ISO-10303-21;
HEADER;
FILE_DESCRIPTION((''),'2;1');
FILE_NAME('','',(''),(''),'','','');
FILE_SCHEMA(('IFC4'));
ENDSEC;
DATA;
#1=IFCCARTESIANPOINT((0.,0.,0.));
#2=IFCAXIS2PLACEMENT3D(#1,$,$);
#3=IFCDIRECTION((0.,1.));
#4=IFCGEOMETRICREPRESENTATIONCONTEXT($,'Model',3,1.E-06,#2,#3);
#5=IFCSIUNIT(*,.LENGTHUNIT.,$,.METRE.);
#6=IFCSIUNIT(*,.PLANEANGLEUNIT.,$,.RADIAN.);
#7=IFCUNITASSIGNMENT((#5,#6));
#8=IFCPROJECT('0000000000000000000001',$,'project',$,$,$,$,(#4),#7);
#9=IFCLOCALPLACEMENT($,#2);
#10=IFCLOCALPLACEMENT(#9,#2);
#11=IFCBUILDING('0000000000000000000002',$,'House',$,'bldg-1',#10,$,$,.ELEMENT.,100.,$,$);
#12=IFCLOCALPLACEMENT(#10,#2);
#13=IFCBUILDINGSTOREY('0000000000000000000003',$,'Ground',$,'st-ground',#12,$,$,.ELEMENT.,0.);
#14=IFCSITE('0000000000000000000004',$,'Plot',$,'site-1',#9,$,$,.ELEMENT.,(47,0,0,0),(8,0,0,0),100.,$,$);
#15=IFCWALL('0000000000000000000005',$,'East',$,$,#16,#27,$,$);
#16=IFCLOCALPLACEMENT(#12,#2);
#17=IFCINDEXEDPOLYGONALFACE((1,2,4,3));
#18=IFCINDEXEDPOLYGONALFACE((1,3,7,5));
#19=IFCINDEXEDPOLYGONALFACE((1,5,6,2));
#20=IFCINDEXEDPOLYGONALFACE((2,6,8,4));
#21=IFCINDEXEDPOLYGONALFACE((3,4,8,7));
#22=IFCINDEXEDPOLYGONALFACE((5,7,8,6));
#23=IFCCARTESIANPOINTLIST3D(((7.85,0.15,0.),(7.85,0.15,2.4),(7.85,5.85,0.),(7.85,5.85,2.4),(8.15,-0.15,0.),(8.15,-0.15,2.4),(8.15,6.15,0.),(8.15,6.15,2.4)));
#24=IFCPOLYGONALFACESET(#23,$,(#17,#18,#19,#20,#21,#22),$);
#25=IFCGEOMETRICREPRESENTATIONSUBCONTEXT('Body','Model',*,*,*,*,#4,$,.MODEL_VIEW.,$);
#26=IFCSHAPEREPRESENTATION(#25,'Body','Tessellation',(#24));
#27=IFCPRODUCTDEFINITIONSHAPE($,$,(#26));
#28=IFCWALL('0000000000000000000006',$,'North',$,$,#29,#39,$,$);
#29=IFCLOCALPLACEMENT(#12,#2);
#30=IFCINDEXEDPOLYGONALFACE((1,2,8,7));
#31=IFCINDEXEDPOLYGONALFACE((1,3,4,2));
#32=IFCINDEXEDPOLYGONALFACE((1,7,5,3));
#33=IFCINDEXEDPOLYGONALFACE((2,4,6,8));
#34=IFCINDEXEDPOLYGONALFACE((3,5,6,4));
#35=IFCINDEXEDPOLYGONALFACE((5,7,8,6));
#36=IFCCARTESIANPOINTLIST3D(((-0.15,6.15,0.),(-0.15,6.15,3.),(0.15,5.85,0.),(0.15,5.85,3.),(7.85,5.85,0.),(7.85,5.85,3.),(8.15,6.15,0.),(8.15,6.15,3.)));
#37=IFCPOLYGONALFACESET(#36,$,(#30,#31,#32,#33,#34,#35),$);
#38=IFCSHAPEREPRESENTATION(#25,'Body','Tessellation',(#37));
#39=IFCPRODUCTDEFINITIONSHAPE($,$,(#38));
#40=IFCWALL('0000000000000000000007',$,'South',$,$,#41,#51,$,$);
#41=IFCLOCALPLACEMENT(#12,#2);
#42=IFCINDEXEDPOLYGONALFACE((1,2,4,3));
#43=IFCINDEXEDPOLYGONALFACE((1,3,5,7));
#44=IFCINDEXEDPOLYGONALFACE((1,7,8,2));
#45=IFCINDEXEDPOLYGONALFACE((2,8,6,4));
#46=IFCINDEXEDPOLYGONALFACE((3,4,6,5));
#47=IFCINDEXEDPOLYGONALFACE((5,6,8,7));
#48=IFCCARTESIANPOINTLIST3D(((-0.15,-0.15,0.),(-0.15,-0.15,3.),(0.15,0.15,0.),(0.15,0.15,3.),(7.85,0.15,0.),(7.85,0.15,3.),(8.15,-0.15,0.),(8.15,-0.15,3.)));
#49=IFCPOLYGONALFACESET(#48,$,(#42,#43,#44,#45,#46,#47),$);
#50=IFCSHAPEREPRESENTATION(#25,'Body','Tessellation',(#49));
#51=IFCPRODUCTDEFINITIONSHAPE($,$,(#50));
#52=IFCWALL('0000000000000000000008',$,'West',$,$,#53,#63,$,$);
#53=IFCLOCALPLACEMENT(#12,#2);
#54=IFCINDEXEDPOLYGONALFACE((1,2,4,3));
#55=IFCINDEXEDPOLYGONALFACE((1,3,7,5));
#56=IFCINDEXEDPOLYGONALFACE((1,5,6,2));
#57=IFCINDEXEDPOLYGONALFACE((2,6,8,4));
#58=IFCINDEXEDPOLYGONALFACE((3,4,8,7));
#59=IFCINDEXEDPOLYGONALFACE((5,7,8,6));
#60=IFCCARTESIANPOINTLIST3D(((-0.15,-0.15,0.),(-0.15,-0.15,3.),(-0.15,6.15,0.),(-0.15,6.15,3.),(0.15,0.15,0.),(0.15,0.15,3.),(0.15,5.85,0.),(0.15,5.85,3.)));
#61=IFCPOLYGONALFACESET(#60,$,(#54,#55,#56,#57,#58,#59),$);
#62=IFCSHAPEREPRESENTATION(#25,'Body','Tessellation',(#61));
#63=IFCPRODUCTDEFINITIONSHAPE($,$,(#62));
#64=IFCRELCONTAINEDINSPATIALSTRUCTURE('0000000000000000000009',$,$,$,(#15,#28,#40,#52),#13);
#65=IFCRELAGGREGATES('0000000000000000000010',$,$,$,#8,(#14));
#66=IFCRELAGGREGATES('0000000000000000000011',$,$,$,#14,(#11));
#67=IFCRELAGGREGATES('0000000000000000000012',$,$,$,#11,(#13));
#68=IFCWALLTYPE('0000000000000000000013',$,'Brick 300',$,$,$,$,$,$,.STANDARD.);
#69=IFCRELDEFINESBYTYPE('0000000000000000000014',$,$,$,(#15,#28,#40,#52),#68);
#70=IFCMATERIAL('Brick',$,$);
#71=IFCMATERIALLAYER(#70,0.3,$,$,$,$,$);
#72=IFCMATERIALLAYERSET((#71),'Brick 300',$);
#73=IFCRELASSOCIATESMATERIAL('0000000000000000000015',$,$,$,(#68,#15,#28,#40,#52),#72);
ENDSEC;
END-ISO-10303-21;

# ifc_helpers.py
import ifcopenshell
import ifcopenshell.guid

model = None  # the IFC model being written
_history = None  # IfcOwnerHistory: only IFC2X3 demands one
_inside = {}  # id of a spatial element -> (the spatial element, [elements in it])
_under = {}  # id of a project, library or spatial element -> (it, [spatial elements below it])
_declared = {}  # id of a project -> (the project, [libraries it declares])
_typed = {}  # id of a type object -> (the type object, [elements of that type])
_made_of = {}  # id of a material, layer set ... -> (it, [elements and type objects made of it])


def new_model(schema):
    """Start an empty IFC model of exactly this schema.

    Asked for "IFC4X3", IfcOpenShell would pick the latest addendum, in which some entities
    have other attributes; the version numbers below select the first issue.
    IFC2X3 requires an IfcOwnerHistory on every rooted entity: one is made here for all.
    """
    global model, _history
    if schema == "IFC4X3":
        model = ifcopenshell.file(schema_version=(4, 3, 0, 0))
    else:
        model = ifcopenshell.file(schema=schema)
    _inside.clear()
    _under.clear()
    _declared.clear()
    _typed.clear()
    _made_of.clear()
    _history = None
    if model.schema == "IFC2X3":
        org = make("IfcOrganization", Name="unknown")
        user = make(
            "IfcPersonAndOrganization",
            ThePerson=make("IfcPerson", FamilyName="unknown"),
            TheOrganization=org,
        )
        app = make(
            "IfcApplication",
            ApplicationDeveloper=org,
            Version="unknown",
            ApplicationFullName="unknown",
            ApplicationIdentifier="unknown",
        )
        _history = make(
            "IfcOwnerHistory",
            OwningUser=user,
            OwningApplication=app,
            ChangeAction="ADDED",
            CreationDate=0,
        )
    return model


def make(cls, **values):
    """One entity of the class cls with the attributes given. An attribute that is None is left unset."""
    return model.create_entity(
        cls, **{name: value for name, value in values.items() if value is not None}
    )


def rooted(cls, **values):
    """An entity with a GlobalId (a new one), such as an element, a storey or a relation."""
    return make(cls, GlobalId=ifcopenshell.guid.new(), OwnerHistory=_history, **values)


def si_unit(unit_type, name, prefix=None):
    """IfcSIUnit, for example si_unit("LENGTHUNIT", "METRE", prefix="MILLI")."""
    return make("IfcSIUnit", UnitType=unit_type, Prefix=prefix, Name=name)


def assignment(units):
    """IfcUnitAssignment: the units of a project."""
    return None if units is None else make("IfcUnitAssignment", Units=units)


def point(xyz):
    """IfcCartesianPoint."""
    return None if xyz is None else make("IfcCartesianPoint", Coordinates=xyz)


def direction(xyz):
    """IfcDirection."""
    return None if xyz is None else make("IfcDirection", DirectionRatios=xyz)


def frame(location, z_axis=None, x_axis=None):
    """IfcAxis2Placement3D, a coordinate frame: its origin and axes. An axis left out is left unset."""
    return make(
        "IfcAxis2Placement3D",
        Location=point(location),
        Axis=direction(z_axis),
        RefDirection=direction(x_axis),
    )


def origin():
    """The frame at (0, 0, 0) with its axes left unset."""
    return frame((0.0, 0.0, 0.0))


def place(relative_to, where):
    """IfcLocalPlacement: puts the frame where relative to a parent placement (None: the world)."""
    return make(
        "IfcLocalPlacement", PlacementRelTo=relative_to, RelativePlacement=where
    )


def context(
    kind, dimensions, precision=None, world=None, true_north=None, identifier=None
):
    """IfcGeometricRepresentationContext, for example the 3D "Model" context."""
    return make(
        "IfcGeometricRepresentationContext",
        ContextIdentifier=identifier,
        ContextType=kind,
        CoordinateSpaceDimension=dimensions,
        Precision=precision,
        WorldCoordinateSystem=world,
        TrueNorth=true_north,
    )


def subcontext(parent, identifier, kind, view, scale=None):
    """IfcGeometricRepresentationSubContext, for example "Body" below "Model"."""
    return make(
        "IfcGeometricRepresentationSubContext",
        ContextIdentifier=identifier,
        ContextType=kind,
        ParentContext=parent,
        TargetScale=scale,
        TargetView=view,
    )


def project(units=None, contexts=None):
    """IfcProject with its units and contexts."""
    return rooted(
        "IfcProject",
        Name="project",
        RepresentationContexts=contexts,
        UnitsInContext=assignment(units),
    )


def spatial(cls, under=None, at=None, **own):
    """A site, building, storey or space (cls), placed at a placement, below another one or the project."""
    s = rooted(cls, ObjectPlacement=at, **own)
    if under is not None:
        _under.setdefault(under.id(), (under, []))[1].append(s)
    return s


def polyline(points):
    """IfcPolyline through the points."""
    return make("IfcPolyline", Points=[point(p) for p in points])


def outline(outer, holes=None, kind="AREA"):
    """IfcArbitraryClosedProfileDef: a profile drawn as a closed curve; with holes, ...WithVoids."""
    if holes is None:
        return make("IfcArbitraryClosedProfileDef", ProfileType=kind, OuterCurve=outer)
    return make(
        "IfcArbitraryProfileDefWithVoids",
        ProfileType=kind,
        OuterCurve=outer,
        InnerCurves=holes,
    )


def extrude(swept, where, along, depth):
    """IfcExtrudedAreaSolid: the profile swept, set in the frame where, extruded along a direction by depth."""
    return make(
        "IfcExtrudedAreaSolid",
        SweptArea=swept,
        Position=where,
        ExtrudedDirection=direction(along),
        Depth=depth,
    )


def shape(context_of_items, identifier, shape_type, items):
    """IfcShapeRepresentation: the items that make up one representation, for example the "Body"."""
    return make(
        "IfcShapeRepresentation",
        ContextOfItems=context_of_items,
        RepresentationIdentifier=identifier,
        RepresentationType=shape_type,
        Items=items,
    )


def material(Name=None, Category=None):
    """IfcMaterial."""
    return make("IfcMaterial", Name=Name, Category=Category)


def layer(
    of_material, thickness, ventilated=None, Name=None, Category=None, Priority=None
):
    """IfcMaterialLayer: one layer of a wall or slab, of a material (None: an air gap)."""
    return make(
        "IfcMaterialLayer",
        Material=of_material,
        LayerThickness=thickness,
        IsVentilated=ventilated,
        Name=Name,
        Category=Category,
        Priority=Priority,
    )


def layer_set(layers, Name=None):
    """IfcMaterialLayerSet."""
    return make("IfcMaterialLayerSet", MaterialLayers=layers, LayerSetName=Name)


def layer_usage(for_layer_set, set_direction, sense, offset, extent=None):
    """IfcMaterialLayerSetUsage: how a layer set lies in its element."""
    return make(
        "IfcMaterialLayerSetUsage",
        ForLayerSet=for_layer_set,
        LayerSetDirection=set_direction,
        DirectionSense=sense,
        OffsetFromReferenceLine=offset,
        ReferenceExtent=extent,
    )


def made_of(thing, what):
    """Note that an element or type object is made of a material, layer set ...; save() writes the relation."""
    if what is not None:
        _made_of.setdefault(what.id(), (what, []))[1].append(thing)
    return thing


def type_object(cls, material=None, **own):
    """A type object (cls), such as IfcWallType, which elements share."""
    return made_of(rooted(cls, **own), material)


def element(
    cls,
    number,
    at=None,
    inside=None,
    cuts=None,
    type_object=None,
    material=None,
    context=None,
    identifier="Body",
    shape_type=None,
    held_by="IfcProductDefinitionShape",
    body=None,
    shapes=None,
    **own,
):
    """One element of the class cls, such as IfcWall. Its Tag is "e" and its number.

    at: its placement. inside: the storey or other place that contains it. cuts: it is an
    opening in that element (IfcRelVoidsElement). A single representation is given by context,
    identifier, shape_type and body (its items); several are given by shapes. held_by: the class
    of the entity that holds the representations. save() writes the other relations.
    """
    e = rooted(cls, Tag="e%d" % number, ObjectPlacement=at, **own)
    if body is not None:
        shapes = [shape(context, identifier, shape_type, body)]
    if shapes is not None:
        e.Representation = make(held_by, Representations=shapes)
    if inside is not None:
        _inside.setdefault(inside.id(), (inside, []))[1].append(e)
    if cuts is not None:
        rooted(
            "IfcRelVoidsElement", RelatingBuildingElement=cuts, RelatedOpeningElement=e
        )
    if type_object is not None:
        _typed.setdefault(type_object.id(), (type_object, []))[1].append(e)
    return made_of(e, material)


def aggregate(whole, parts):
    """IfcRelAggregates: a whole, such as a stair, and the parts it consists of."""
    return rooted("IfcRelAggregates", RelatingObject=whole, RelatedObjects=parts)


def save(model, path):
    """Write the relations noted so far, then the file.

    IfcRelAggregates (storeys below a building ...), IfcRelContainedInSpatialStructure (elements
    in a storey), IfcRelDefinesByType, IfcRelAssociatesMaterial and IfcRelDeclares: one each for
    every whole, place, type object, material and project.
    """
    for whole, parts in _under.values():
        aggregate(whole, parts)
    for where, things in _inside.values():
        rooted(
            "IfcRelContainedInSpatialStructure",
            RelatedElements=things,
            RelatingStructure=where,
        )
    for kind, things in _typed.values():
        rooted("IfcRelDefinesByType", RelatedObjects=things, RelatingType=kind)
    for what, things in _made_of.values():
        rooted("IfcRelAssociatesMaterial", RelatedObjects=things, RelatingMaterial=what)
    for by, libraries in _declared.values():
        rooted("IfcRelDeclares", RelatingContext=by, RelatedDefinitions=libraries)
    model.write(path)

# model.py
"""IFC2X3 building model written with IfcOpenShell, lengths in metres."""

from ifc_helpers import new_model, si_unit, direction, origin, place, context, subcontext, project, spatial, polyline, outline, extrude, material, layer, layer_set, layer_usage, type_object, element, save


model = new_model("IFC2X3")

# Units and contexts
model_context = context("Model", 3, precision=1e-06, world=origin(), true_north=direction((0.0, 1.0)))
body_context = subcontext(model_context, "Body", "Model", "MODEL_VIEW")
ifc_project = project(units=[si_unit("LENGTHUNIT", "METRE"), si_unit("PLANEANGLEUNIT", "RADIAN")], contexts=[model_context])

# Site, building, storey
site_placement = place(None, origin())
site = spatial("IfcSite", under=ifc_project, at=site_placement, Name="Plot", ObjectType="site-1", CompositionType="ELEMENT", RefLatitude=(47, 0, 0, 0), RefLongitude=(8, 0, 0, 0), RefElevation=100.0)
building_placement = place(site_placement, origin())
building = spatial("IfcBuilding", under=site, at=building_placement, Name="House", ObjectType="bldg-1", CompositionType="ELEMENT", ElevationOfRefHeight=100.0)
storey_placement = place(building_placement, origin())
storey = spatial("IfcBuildingStorey", under=building, at=storey_placement, Name="Ground", ObjectType="st-ground", CompositionType="ELEMENT", Elevation=0.0)

# Walls
ifc_material = material(Name="Brick")
ifc_layer = layer(ifc_material, 0.3)
ifc_layer_set = layer_set([ifc_layer], Name="Brick 300")
ifc_layer_usage_1 = layer_usage(ifc_layer_set, "AXIS2", "NEGATIVE", 0.15)
wall_type = type_object("IfcWallType", Name="Brick 300", PredefinedType="STANDARD", material=ifc_layer_set)
wall_1_placement = place(storey_placement, origin())
element("IfcWall", 1, at=wall_1_placement, inside=storey, type_object=wall_type, material=ifc_layer_usage_1, Name="East", context=body_context, shape_type="SweptSolid", body=[
    extrude(outline(polyline([(8.15, -0.15), (8.15, 6.15), (7.85, 5.85), (7.85, 0.15), (8.15, -0.15)])), origin(), (0.0, 0.0, 1.0), 2.4),
])
ifc_layer_usage_2 = layer_usage(ifc_layer_set, "AXIS2", "NEGATIVE", 0.15)
wall_2_placement = place(storey_placement, origin())
element("IfcWall", 2, at=wall_2_placement, inside=storey, type_object=wall_type, material=ifc_layer_usage_2, Name="North", context=body_context, shape_type="SweptSolid", body=[
    extrude(outline(polyline([(8.15, 6.15), (-0.15, 6.15), (0.15, 5.85), (7.85, 5.85), (8.15, 6.15)])), origin(), (0.0, 0.0, 1.0), 3.0),
])
ifc_layer_usage_3 = layer_usage(ifc_layer_set, "AXIS2", "NEGATIVE", 0.15)
wall_3_placement = place(storey_placement, origin())
element("IfcWall", 3, at=wall_3_placement, inside=storey, type_object=wall_type, material=ifc_layer_usage_3, Name="South", context=body_context, shape_type="SweptSolid", body=[
    extrude(outline(polyline([(-0.15, -0.15), (8.15, -0.15), (7.85, 0.15), (0.15, 0.15), (-0.15, -0.15)])), origin(), (0.0, 0.0, 1.0), 3.0),
])
ifc_layer_usage_4 = layer_usage(ifc_layer_set, "AXIS2", "NEGATIVE", 0.15)
wall_4_placement = place(storey_placement, origin())
element("IfcWall", 4, at=wall_4_placement, inside=storey, type_object=wall_type, material=ifc_layer_usage_4, Name="West", context=body_context, shape_type="SweptSolid", body=[
    extrude(outline(polyline([(-0.15, 6.15), (-0.15, -0.15), (0.15, 0.15), (0.15, 5.85), (-0.15, 6.15)])), origin(), (0.0, 0.0, 1.0), 3.0),
])

save(model, "model.ifc")
